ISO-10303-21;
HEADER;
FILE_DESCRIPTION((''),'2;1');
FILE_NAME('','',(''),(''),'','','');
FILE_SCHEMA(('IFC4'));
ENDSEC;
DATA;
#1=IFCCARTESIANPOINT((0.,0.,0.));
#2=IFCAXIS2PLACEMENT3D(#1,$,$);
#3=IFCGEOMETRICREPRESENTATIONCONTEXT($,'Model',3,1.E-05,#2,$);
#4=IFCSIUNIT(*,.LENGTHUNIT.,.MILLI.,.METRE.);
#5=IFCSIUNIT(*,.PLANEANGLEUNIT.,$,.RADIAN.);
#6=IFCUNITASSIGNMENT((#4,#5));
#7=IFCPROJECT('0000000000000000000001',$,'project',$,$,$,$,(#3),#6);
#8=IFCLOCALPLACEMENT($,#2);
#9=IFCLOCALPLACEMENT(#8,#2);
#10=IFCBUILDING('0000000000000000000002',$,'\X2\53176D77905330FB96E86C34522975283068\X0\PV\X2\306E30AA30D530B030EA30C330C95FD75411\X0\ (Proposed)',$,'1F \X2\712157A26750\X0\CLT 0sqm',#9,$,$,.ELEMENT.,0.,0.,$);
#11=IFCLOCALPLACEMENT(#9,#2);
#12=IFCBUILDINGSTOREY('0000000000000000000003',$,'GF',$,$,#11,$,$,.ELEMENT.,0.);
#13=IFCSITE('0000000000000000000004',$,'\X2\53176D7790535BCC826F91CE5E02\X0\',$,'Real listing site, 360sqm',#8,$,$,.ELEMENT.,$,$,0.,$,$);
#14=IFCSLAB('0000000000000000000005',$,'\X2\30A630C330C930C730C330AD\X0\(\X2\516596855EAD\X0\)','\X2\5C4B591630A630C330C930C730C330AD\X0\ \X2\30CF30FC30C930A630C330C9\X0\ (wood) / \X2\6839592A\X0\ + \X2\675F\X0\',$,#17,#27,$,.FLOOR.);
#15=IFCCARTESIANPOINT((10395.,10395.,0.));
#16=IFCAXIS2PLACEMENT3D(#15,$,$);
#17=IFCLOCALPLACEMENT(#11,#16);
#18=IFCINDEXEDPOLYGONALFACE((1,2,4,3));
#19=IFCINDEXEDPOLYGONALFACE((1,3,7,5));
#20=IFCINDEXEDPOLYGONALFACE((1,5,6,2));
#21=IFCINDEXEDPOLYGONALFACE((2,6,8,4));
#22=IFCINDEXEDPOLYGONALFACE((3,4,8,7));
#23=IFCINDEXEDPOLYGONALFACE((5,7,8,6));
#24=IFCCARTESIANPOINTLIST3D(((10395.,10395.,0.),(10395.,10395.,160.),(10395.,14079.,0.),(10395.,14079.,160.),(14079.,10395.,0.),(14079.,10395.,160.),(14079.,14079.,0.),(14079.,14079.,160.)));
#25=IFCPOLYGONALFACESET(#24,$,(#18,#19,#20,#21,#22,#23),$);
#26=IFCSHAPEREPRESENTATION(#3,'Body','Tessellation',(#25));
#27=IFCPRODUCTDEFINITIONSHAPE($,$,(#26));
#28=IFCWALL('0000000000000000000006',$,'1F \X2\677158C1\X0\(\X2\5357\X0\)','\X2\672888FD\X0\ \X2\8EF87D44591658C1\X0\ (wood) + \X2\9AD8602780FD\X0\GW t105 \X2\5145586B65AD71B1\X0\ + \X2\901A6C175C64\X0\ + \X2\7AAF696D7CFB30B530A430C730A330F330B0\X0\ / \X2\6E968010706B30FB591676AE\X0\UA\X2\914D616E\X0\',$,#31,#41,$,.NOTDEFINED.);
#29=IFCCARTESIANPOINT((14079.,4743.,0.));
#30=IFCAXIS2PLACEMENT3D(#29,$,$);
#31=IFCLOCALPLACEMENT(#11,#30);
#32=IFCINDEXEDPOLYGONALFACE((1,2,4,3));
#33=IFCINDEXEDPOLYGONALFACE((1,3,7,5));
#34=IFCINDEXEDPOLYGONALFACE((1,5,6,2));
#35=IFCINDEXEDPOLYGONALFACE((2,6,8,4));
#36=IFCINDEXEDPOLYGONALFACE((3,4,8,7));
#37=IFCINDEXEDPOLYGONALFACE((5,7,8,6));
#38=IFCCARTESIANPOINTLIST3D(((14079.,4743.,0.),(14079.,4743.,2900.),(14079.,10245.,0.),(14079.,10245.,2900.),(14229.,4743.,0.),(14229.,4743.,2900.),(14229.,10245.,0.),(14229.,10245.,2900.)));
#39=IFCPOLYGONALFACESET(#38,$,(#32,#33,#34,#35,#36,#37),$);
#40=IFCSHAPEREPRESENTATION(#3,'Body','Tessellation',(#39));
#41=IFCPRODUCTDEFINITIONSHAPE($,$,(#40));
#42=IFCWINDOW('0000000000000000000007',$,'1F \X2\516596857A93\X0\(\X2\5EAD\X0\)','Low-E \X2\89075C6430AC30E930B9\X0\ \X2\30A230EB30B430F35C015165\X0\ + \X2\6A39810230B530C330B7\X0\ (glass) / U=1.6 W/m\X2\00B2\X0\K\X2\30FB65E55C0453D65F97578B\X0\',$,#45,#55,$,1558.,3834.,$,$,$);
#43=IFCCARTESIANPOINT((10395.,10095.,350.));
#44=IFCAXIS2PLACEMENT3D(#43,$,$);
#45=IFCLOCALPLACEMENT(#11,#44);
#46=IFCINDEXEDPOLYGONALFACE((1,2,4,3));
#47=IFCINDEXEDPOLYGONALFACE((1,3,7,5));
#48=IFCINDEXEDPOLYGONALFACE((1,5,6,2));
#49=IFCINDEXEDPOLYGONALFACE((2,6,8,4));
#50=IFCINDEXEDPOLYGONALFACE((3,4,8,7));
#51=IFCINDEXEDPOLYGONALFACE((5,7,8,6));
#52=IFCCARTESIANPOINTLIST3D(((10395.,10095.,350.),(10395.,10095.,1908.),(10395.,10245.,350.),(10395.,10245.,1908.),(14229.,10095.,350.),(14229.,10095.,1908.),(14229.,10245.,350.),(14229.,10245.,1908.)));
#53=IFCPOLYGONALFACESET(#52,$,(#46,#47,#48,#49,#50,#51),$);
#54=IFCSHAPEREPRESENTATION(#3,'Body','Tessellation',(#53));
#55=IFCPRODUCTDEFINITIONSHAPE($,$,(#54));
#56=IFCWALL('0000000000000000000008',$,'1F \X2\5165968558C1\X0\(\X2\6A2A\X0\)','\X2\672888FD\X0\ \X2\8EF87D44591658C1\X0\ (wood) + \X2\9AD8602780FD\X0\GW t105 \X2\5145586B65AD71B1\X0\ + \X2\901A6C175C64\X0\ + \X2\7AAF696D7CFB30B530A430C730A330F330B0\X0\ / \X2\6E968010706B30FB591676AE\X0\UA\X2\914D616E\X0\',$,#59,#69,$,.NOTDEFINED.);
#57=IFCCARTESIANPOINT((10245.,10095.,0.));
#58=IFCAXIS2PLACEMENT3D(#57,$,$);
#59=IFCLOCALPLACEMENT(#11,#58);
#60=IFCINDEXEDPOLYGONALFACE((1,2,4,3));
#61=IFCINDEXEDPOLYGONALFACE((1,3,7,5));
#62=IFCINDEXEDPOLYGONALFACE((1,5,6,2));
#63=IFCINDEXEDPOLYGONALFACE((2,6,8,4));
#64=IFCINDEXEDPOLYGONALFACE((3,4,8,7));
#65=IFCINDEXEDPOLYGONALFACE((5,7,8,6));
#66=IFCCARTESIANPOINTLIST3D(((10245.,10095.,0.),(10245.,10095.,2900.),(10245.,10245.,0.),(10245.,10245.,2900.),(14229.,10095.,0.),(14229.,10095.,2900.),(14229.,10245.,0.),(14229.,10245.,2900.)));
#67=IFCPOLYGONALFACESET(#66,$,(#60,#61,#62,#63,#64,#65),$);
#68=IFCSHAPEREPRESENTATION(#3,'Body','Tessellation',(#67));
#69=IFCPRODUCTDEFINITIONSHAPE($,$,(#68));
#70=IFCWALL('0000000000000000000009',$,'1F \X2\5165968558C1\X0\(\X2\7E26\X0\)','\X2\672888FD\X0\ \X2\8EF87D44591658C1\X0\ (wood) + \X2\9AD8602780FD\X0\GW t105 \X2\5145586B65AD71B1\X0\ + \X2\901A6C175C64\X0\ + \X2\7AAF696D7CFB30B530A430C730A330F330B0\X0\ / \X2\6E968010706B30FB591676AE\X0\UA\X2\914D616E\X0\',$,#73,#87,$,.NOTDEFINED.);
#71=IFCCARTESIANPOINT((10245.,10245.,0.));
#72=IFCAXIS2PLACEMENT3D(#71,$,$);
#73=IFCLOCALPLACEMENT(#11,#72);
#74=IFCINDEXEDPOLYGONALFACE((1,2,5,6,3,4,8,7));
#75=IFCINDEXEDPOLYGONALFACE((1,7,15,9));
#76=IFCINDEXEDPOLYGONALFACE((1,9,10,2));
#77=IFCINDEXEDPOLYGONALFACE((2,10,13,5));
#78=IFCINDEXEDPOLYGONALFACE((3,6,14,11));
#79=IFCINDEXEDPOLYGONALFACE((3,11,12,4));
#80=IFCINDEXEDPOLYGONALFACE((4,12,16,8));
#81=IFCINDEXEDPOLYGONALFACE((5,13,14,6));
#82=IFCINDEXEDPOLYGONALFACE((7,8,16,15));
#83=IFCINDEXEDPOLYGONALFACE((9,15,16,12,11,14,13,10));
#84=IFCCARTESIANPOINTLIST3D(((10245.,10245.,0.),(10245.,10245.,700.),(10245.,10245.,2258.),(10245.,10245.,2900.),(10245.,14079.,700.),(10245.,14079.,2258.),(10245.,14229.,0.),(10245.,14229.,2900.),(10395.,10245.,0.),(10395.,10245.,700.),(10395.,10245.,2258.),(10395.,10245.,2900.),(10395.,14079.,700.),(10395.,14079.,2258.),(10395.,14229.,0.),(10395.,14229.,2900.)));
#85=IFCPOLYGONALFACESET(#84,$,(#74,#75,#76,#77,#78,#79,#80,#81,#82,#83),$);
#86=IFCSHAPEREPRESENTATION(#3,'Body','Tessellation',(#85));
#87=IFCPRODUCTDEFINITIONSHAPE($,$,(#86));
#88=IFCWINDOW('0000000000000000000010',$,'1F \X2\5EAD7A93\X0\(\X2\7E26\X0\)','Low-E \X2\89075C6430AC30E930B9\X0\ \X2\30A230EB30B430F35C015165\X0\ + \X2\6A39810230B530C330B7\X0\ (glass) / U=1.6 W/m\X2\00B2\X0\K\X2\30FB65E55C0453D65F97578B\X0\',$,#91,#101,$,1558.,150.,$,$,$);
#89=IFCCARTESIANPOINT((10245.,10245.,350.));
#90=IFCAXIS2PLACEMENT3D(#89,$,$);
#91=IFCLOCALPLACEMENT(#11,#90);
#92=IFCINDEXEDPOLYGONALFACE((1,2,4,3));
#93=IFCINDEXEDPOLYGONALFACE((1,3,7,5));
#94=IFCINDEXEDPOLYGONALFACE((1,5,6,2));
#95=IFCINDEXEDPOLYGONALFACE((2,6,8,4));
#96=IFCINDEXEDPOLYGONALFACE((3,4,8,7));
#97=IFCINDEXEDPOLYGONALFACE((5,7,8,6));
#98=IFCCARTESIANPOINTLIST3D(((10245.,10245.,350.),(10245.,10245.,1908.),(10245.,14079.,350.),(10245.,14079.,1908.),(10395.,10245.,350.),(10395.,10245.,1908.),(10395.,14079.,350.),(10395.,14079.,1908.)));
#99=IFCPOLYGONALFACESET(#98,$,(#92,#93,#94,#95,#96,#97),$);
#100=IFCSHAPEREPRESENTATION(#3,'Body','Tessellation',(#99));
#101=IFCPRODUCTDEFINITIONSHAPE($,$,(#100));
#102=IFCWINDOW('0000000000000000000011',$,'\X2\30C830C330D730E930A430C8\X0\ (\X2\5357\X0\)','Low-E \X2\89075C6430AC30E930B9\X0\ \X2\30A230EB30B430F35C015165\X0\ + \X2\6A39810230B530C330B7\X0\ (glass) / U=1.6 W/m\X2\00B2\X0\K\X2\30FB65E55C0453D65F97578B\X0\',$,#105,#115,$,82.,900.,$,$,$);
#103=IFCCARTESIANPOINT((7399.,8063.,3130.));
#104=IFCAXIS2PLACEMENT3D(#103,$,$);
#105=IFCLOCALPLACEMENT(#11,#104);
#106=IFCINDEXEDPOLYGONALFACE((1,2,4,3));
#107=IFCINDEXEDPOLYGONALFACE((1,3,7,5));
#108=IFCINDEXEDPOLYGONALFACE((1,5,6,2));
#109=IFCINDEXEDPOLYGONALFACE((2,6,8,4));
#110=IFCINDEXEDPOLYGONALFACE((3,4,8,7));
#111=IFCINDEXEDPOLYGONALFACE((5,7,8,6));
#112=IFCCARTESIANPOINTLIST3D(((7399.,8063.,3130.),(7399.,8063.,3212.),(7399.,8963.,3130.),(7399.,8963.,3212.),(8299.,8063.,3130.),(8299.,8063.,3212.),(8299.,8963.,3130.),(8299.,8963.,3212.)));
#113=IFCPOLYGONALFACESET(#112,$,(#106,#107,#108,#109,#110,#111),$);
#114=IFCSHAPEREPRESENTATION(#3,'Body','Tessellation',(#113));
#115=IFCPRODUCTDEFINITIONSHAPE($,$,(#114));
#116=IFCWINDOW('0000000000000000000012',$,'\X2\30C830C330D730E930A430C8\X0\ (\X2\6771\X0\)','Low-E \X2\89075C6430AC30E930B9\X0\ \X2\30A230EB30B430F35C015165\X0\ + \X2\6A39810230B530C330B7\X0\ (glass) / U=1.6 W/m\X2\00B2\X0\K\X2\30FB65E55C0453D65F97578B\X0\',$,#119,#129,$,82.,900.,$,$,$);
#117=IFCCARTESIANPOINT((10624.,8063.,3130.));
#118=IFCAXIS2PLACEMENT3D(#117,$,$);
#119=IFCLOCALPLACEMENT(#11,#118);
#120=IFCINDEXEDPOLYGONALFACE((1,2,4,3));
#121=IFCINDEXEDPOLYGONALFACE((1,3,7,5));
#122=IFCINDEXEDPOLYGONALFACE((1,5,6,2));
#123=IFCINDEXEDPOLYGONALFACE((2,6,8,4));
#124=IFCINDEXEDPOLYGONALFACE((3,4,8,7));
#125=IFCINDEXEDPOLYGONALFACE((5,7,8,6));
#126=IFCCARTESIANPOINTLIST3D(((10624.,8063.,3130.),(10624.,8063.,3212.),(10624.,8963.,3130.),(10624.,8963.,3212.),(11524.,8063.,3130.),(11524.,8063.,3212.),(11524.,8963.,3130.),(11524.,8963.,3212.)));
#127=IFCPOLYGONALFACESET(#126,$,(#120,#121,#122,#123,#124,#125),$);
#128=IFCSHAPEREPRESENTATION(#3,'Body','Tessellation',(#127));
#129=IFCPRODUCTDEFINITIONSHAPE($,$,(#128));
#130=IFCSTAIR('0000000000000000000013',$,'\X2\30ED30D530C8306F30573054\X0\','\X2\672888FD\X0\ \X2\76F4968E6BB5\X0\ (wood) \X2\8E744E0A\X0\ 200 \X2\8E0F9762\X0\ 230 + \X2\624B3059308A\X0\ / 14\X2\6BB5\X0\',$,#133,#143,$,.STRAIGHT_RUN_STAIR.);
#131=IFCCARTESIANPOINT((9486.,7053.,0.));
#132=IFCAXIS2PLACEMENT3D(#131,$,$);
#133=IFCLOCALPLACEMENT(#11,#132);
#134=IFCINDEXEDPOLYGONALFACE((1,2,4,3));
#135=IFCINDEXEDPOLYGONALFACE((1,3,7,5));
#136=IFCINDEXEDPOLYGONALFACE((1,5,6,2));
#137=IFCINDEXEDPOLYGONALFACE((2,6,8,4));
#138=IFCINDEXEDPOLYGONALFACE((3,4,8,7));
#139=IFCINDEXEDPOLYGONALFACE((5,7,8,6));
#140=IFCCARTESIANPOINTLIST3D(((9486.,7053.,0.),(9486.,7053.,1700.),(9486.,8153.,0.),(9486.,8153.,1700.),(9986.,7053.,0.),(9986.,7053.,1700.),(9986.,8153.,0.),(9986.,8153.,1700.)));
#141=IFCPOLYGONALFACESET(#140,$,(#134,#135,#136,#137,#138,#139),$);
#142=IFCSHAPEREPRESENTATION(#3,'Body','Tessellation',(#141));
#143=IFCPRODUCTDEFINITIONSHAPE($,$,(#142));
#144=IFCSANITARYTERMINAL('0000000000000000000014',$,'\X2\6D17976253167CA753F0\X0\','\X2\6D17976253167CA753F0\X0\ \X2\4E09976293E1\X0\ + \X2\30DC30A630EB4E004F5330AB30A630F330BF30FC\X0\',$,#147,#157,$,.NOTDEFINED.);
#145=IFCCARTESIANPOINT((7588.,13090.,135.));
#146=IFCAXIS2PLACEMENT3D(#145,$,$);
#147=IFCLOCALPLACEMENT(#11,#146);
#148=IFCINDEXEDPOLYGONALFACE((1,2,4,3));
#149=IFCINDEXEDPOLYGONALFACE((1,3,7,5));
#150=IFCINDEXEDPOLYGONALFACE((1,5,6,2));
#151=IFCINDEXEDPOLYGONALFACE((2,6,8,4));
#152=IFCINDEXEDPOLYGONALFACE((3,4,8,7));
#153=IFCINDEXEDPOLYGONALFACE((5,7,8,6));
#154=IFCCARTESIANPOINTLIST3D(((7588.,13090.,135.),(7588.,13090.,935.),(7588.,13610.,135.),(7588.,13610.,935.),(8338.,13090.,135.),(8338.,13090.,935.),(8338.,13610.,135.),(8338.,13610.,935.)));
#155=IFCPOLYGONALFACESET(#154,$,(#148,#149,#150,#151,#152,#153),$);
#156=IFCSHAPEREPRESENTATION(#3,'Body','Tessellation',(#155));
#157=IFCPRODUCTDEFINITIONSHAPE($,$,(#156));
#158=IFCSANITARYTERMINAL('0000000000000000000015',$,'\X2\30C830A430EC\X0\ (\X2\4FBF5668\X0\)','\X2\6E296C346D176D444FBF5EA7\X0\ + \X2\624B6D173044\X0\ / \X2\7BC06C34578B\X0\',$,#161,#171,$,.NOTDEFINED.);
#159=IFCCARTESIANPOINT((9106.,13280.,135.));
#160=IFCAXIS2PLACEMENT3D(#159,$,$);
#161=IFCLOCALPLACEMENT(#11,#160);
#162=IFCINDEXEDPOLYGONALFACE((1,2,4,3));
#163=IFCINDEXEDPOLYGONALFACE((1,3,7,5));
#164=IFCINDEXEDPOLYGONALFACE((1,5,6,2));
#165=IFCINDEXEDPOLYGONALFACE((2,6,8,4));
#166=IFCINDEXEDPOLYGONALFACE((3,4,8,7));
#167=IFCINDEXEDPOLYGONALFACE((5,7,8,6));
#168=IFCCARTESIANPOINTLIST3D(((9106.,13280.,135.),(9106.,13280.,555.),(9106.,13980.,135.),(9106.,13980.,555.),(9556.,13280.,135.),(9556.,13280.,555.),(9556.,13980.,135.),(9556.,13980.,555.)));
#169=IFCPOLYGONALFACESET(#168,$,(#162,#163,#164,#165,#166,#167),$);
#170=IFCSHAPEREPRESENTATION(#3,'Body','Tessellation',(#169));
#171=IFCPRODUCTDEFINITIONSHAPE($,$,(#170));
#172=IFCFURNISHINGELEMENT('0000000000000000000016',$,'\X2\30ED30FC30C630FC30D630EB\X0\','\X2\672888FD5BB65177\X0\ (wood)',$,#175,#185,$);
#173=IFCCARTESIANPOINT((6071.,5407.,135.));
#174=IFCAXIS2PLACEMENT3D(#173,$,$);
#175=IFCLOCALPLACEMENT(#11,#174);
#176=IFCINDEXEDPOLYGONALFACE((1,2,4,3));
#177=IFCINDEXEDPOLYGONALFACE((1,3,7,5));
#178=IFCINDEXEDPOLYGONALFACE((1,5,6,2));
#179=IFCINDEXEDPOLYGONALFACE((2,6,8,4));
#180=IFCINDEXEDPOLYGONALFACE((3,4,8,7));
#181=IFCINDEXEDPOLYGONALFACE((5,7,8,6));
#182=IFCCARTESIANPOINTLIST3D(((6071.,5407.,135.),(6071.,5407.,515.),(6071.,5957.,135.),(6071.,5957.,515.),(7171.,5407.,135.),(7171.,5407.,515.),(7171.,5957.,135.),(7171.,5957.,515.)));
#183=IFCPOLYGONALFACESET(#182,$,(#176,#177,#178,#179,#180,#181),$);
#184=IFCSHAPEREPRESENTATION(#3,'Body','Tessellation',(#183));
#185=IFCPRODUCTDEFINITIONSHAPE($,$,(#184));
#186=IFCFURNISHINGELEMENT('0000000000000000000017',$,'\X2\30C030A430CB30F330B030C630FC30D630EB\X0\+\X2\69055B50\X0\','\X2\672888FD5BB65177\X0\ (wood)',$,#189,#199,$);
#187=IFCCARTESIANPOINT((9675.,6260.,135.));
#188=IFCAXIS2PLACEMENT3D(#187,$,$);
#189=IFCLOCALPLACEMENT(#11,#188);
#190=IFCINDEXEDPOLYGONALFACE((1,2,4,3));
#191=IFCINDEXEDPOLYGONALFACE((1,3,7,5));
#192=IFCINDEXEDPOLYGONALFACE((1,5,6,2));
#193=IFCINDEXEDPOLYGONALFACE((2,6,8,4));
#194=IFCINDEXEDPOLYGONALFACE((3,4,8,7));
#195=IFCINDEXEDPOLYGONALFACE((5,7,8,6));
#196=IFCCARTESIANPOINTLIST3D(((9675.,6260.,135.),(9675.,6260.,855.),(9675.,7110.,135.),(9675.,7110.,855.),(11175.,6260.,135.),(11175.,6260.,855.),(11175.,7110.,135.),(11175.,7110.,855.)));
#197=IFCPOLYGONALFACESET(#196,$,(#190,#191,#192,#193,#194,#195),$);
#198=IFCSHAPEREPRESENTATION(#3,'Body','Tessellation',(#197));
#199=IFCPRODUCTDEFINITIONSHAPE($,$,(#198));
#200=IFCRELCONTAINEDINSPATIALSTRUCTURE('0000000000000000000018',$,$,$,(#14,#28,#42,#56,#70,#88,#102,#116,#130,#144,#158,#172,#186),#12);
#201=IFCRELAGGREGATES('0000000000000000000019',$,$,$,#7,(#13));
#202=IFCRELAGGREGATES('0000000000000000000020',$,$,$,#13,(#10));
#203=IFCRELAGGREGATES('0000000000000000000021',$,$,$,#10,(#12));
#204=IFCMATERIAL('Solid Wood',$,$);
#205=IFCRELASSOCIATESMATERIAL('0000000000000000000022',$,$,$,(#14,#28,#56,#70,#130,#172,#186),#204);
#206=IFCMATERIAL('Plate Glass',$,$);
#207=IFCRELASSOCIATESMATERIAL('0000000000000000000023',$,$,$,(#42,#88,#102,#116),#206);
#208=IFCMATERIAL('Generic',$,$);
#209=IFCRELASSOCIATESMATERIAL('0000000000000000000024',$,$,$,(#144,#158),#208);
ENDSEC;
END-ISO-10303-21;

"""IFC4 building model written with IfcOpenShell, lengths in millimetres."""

from ifc_helpers import new_model, si_unit, frame, frame_2d, origin, place, context, project, spatial, rectangle, extrude, material, element, fill, save


model = new_model("IFC4")

# Units and contexts
model_context = context("Model", 3, precision=1e-05, world=origin())
ifc_project = project(units=[si_unit("LENGTHUNIT", "METRE", prefix="MILLI"), si_unit("PLANEANGLEUNIT", "RADIAN")], contexts=[model_context])

# Site, building, storey
site_placement = place(None, origin())
site = spatial("IfcSite", under=ifc_project, at=site_placement, Name="北海道富良野市", ObjectType="Real listing site, 360sqm", CompositionType="ELEMENT", RefElevation=0.0)
building_placement = place(site_placement, origin())
building = spatial("IfcBuilding", under=site, at=building_placement, Name="北海道・雨水利用とPVのオフグリッド志向 (Proposed)", ObjectType="1F 無垢材CLT 0sqm", CompositionType="ELEMENT", ElevationOfRefHeight=0.0, ElevationOfTerrain=0.0)
storey_placement = place(building_placement, origin())
storey = spatial("IfcBuildingStorey", under=building, at=storey_placement, Name="GF", CompositionType="ELEMENT", Elevation=0.0)

# Slab
ifc_material_1 = material(Name="Solid Wood")
slab_placement = place(storey_placement, frame((10395.0, 10395.0, 0.0)))
element("IfcSlab", 1, at=slab_placement, inside=storey, material=ifc_material_1, Name="ウッドデッキ(入隅庭)", Description="屋外ウッドデッキ ハードウッド (wood) / 根太 + 束", PredefinedType="FLOOR", context=model_context, shape_type="SweptSolid", body=[
    extrude(rectangle(XDim=3684.0, YDim=3684.0, at=frame_2d((1842.0, 1842.0))), frame((10395.0, 10395.0, 0.0)), (0.0, 0.0, 1.0), 160.0),
])

# Wall, opening, window
wall_1_placement = place(storey_placement, frame((14079.0, 4743.0, 0.0)))
wall_1 = element("IfcWall", 2, at=wall_1_placement, inside=storey, material=ifc_material_1, Name="1F 東壁(南)", Description="木製 軸組外壁 (wood) + 高性能GW t105 充填断熱 + 通気層 + 窯業系サイディング / 準耐火・外皮UA配慮", PredefinedType="NOTDEFINED", context=model_context, shape_type="SweptSolid", body=[
    extrude(rectangle(XDim=150.0, YDim=5502.0, at=frame_2d((75.0, 2751.0))), frame((14079.0, 4743.0, 0.0)), (0.0, 0.0, 1.0), 2900.0),
])
opening_1_placement = place(storey_placement, frame((10395.0, 10095.0, 350.0)))
opening_1 = element("IfcOpeningElement", 3, at=opening_1_placement, cuts=wall_1, PredefinedType="NOTDEFINED", context=model_context, shape_type="SweptSolid", body=[
    extrude(rectangle(XDim=3834.0, YDim=150.0, at=frame_2d((1917.0, 75.0))), frame((10395.0, 10095.0, 350.0)), (0.0, 0.0, 1.0), 1558.0),
])
ifc_material_2 = material(Name="Plate Glass")
window_1_placement = place(storey_placement, frame((10395.0, 10095.0, 350.0)))
window_1 = element("IfcWindow", 4, at=window_1_placement, inside=storey, material=ifc_material_2, Name="1F 入隅窓(庭)", Description="Low-E 複層ガラス アルゴン封入 + 樹脂サッシ (glass) / U=1.6 W/m²K・日射取得型", OverallHeight=1558.0, OverallWidth=3834.0, context=model_context, shape_type="SweptSolid", body=[
    extrude(rectangle(XDim=3834.0, YDim=150.0, at=frame_2d((1917.0, 75.0))), frame((10395.0, 10095.0, 350.0)), (0.0, 0.0, 1.0), 1558.0),
])
fill(opening_1, window_1)

# Wall
wall_2_placement = place(storey_placement, frame((10245.0, 10095.0, 0.0)))
element("IfcWall", 5, at=wall_2_placement, inside=storey, material=ifc_material_1, Name="1F 入隅壁(横)", Description="木製 軸組外壁 (wood) + 高性能GW t105 充填断熱 + 通気層 + 窯業系サイディング / 準耐火・外皮UA配慮", PredefinedType="NOTDEFINED", context=model_context, shape_type="SweptSolid", body=[
    extrude(rectangle(XDim=3984.0, YDim=150.0, at=frame_2d((1992.0, 75.0))), frame((10245.0, 10095.0, 0.0)), (0.0, 0.0, 1.0), 2900.0),
])

# Wall, opening, window
wall_3_placement = place(storey_placement, frame((10245.0, 10245.0, 0.0)))
wall_3 = element("IfcWall", 6, at=wall_3_placement, inside=storey, material=ifc_material_1, Name="1F 入隅壁(縦)", Description="木製 軸組外壁 (wood) + 高性能GW t105 充填断熱 + 通気層 + 窯業系サイディング / 準耐火・外皮UA配慮", PredefinedType="NOTDEFINED", context=model_context, shape_type="SweptSolid", body=[
    extrude(rectangle(XDim=150.0, YDim=3984.0, at=frame_2d((75.0, 1992.0))), frame((10245.0, 10245.0, 0.0)), (0.0, 0.0, 1.0), 2900.0),
])
opening_2_placement = place(storey_placement, frame((10245.0, 10245.0, 350.0)))
opening_2 = element("IfcOpeningElement", 7, at=opening_2_placement, cuts=wall_3, PredefinedType="NOTDEFINED", context=model_context, shape_type="SweptSolid", body=[
    extrude(rectangle(XDim=150.0, YDim=3834.0, at=frame_2d((75.0, 1917.0))), frame((10245.0, 10245.0, 350.0)), (0.0, 0.0, 1.0), 1558.0),
])
window_2_placement = place(storey_placement, frame((10245.0, 10245.0, 350.0)))
window_2 = element("IfcWindow", 8, at=window_2_placement, inside=storey, material=ifc_material_2, Name="1F 庭窓(縦)", Description="Low-E 複層ガラス アルゴン封入 + 樹脂サッシ (glass) / U=1.6 W/m²K・日射取得型", OverallHeight=1558.0, OverallWidth=150.0, context=model_context, shape_type="SweptSolid", body=[
    extrude(rectangle(XDim=150.0, YDim=3834.0, at=frame_2d((75.0, 1917.0))), frame((10245.0, 10245.0, 350.0)), (0.0, 0.0, 1.0), 1558.0),
])
fill(opening_2, window_2)

# Windows
window_3_placement = place(storey_placement, frame((7399.0, 8063.0, 3130.0)))
element("IfcWindow", 9, at=window_3_placement, inside=storey, material=ifc_material_2, Name="トップライト (南)", Description="Low-E 複層ガラス アルゴン封入 + 樹脂サッシ (glass) / U=1.6 W/m²K・日射取得型", OverallHeight=82.0, OverallWidth=900.0, context=model_context, shape_type="SweptSolid", body=[
    extrude(rectangle(XDim=900.0, YDim=900.0, at=frame_2d((450.0, 450.0))), frame((7399.0, 8063.0, 3130.0)), (0.0, 0.0, 1.0), 82.0),
])
window_4_placement = place(storey_placement, frame((10624.0, 8063.0, 3130.0)))
element("IfcWindow", 10, at=window_4_placement, inside=storey, material=ifc_material_2, Name="トップライト (東)", Description="Low-E 複層ガラス アルゴン封入 + 樹脂サッシ (glass) / U=1.6 W/m²K・日射取得型", OverallHeight=82.0, OverallWidth=900.0, context=model_context, shape_type="SweptSolid", body=[
    extrude(rectangle(XDim=900.0, YDim=900.0, at=frame_2d((450.0, 450.0))), frame((10624.0, 8063.0, 3130.0)), (0.0, 0.0, 1.0), 82.0),
])

# Stair
stair_placement = place(storey_placement, frame((9486.0, 7053.0, 0.0)))
element("IfcStair", 11, at=stair_placement, inside=storey, material=ifc_material_1, Name="ロフトはしご", Description="木製 直階段 (wood) 蹴上 200 踏面 230 + 手すり / 14段", PredefinedType="STRAIGHT_RUN_STAIR", context=model_context, shape_type="SweptSolid", body=[
    extrude(rectangle(XDim=500.0, YDim=1100.0, at=frame_2d((250.0, 550.0))), frame((9486.0, 7053.0, 0.0)), (0.0, 0.0, 1.0), 1700.0),
])

# Sanitary terminals
ifc_material_3 = material(Name="Generic")
sanitary_terminal_1_placement = place(storey_placement, frame((7588.0, 13090.0, 135.0)))
element("IfcSanitaryTerminal", 12, at=sanitary_terminal_1_placement, inside=storey, material=ifc_material_3, Name="洗面化粧台", Description="洗面化粧台 三面鏡 + ボウル一体カウンター", PredefinedType="NOTDEFINED", context=model_context, shape_type="SweptSolid", body=[
    extrude(rectangle(XDim=750.0, YDim=520.0, at=frame_2d((375.0, 260.0))), frame((7588.0, 13090.0, 135.0)), (0.0, 0.0, 1.0), 800.0),
])
sanitary_terminal_2_placement = place(storey_placement, frame((9106.0, 13280.0, 135.0)))
element("IfcSanitaryTerminal", 13, at=sanitary_terminal_2_placement, inside=storey, material=ifc_material_3, Name="トイレ (便器)", Description="温水洗浄便座 + 手洗い / 節水型", PredefinedType="NOTDEFINED", context=model_context, shape_type="SweptSolid", body=[
    extrude(rectangle(XDim=450.0, YDim=700.0, at=frame_2d((225.0, 350.0))), frame((9106.0, 13280.0, 135.0)), (0.0, 0.0, 1.0), 420.0),
])

# Furnishing elements
furnishing_1_placement = place(storey_placement, frame((6071.0, 5407.0, 135.0)))
element("IfcFurnishingElement", 14, at=furnishing_1_placement, inside=storey, material=ifc_material_1, Name="ローテーブル", Description="木製家具 (wood)", context=model_context, shape_type="SweptSolid", body=[
    extrude(rectangle(XDim=1100.0, YDim=550.0, at=frame_2d((550.0, 275.0))), frame((6071.0, 5407.0, 135.0)), (0.0, 0.0, 1.0), 380.0),
])
furnishing_2_placement = place(storey_placement, frame((9675.0, 6260.0, 135.0)))
element("IfcFurnishingElement", 15, at=furnishing_2_placement, inside=storey, material=ifc_material_1, Name="ダイニングテーブル+椅子", Description="木製家具 (wood)", context=model_context, shape_type="SweptSolid", body=[
    extrude(rectangle(XDim=1500.0, YDim=850.0, at=frame_2d((750.0, 425.0))), frame((9675.0, 6260.0, 135.0)), (0.0, 0.0, 1.0), 720.0),
])

save(model, "model.ifc")
